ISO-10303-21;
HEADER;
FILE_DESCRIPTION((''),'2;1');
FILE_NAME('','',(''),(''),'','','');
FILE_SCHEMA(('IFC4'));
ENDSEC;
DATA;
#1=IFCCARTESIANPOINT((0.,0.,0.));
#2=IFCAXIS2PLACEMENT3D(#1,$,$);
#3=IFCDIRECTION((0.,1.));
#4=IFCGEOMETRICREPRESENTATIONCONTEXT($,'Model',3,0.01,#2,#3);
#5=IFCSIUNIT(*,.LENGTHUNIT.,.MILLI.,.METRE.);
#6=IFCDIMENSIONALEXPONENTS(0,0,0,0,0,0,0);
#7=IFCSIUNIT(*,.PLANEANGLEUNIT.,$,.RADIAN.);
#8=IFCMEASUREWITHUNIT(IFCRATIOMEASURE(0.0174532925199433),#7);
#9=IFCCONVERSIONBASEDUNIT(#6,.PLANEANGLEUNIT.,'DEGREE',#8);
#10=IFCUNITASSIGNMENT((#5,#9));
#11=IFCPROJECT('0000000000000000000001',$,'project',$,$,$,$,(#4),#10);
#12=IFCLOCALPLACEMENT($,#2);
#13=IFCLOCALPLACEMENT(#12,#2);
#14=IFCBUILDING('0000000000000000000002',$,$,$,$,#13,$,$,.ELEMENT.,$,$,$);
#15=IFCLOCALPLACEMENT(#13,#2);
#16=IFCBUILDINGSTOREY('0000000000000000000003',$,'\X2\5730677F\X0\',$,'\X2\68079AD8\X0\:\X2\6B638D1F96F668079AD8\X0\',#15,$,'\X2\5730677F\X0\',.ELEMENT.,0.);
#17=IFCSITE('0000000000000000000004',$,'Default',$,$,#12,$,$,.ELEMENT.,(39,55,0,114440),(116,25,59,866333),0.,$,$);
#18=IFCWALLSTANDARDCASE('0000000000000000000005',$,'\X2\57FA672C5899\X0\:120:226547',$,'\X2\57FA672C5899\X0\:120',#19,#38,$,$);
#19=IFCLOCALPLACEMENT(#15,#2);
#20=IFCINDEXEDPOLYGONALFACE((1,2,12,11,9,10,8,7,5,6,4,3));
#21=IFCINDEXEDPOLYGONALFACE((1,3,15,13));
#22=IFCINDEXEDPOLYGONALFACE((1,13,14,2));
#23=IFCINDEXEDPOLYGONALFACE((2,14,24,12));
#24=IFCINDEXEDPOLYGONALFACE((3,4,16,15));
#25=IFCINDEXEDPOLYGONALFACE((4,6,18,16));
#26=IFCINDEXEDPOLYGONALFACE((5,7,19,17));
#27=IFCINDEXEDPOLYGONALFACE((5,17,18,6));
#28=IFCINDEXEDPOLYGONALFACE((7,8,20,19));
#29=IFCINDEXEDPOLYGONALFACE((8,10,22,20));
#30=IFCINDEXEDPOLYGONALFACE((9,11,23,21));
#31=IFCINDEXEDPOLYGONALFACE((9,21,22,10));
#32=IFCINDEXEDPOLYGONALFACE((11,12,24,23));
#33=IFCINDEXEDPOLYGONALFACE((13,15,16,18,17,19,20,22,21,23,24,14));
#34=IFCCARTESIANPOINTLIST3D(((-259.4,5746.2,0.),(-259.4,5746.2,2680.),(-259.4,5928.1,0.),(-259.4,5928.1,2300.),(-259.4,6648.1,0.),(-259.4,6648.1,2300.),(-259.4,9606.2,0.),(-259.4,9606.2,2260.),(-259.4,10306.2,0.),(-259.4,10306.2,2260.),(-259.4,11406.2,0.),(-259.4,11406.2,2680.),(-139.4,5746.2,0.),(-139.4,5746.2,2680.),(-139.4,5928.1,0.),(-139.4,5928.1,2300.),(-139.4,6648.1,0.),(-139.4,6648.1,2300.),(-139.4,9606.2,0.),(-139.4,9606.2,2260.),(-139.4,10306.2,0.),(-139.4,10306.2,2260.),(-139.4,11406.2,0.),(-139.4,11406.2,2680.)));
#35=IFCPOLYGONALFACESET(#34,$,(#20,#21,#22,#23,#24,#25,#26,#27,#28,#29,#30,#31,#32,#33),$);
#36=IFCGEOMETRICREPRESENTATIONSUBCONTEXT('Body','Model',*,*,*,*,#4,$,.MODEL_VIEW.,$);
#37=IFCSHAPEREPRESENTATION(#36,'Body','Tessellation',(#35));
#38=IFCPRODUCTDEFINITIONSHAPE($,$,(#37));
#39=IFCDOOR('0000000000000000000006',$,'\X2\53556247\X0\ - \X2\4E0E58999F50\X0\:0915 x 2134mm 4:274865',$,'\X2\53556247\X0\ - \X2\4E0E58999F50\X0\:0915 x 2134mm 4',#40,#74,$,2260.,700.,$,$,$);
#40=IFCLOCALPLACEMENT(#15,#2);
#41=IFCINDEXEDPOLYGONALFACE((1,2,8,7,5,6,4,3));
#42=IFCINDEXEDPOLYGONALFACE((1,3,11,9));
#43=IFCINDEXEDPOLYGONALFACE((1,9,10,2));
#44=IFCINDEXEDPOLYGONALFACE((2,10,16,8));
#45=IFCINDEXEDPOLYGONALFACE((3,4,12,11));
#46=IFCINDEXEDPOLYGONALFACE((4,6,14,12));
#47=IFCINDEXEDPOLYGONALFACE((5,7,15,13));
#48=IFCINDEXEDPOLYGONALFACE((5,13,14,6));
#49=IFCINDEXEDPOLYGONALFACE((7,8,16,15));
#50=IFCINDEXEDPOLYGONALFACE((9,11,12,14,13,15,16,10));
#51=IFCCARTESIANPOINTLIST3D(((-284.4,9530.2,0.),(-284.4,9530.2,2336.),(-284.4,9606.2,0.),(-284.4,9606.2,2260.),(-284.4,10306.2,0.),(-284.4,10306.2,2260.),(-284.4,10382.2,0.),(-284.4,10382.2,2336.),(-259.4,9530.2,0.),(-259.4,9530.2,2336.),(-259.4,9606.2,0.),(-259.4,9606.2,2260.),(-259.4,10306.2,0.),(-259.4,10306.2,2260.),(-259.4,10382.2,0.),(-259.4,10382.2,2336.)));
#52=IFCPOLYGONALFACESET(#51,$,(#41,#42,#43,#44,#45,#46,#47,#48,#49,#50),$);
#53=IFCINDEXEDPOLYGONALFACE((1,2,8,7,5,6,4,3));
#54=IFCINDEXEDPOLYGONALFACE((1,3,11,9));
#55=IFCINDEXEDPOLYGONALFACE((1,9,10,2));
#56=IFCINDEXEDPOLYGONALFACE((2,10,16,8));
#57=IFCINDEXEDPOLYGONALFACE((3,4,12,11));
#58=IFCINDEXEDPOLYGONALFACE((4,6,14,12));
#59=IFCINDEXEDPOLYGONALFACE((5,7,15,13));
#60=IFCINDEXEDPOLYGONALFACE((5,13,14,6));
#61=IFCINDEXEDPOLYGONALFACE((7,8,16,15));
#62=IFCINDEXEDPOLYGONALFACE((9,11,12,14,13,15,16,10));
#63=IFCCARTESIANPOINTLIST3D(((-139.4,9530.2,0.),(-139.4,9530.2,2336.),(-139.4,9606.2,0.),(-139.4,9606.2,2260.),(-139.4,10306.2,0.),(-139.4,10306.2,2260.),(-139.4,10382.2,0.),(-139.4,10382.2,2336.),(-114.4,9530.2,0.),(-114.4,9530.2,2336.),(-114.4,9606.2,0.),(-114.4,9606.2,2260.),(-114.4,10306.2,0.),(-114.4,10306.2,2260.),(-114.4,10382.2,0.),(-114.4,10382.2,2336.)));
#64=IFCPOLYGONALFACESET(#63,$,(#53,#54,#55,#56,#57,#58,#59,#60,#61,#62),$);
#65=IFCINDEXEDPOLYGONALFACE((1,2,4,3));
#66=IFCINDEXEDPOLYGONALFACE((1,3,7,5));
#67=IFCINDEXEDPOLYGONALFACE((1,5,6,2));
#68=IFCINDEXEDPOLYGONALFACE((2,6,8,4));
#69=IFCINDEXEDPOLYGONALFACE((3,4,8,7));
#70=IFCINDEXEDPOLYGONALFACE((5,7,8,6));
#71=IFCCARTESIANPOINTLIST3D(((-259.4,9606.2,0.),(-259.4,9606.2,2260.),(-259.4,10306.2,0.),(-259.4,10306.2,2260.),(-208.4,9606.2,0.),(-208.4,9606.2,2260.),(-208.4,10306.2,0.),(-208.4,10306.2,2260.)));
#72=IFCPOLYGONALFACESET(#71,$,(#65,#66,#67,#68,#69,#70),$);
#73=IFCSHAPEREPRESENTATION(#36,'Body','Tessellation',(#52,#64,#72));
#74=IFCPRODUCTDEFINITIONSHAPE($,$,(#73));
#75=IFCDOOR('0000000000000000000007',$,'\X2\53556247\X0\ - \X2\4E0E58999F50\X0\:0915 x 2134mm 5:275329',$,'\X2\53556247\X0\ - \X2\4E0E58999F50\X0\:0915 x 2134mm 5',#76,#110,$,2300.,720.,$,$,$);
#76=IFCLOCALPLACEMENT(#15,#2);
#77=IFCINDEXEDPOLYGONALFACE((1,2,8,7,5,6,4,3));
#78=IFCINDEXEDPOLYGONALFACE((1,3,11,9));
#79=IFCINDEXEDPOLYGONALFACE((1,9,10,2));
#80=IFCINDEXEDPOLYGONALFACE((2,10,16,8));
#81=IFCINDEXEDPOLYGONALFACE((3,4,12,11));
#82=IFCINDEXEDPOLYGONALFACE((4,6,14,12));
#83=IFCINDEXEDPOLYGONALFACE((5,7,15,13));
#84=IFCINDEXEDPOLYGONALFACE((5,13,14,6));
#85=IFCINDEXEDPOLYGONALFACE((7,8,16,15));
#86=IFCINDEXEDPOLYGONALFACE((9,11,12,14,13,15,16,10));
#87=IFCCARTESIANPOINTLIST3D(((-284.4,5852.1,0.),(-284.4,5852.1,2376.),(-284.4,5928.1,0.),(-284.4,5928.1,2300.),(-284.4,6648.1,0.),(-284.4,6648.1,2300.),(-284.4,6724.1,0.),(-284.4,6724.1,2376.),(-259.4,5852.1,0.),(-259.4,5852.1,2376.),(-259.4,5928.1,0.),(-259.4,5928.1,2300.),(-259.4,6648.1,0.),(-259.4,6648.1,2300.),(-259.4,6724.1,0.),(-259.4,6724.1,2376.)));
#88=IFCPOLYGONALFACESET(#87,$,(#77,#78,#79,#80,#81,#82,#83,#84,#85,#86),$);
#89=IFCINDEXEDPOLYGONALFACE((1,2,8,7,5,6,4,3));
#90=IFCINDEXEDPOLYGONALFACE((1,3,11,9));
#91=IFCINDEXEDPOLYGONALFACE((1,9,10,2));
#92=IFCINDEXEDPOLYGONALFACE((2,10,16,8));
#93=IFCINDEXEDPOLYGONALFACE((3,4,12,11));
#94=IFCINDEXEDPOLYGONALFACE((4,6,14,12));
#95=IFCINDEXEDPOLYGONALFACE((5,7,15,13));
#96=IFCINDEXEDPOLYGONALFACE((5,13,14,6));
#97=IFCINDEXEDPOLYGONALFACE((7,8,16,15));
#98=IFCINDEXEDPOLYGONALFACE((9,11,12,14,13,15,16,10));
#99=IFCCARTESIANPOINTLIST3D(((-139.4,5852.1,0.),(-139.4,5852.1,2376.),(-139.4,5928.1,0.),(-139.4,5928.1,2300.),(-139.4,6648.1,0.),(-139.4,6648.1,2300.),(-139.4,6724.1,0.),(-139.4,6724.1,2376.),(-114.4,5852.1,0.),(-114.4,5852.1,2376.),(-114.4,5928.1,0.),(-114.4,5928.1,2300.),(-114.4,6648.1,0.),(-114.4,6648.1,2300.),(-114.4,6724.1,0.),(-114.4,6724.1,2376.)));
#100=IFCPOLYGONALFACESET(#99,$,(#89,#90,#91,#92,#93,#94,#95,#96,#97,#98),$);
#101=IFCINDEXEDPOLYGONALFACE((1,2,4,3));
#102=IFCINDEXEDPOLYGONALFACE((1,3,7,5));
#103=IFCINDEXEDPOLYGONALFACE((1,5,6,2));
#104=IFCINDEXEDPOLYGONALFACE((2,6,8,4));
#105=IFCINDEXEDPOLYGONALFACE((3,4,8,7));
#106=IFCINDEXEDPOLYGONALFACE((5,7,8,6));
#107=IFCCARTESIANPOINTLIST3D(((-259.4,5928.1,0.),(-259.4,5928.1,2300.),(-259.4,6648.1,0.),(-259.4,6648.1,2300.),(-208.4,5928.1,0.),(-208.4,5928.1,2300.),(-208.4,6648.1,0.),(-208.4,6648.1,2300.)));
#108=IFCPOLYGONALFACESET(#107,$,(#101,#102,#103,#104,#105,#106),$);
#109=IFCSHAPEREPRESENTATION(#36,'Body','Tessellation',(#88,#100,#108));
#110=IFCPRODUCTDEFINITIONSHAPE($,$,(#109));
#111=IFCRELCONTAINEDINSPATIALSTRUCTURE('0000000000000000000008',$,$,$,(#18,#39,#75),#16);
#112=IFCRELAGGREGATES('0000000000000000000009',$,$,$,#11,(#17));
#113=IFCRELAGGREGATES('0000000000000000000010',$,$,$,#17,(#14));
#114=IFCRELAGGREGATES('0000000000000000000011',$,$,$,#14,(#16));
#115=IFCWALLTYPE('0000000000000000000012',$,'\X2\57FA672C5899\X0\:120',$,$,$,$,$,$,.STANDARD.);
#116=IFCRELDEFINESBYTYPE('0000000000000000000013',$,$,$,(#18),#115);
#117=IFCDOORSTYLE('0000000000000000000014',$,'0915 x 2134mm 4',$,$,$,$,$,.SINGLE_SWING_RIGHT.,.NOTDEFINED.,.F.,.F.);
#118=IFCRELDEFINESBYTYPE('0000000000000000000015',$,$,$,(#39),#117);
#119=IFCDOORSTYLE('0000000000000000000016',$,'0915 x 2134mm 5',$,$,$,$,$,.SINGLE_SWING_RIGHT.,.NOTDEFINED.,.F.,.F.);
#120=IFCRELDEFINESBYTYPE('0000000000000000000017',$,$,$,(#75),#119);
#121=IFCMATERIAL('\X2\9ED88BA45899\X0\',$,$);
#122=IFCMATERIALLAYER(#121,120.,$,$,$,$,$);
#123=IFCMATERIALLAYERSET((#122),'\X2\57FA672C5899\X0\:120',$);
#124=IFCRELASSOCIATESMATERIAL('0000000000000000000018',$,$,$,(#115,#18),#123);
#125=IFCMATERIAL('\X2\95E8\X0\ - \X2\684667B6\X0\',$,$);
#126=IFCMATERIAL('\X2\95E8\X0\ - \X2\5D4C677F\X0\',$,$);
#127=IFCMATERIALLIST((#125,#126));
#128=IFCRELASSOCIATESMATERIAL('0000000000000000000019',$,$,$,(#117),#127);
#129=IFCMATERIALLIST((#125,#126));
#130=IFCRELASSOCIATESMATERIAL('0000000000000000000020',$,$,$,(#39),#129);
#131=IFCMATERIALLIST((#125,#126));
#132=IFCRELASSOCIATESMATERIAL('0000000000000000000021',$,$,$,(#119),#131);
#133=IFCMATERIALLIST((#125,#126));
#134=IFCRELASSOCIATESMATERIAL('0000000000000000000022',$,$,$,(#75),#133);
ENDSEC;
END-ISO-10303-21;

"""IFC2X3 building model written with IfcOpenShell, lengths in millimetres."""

from ifc_helpers import new_model, entity, si_unit, converted_unit, direction, frame, frame_2d, origin, origin_2d_with_axis, place, context, subcontext, project, spatial, polyline, rectangle, outline, extrude, source, transform, mapped, material, material_list, layer, layer_set, layer_usage, type_object, type_shapes, element, fill, save


model = new_model("IFC2X3")

# Units and contexts
model_context = context("Model", 3, precision=0.01, world=origin(), true_north=direction((0.0, 1.0)))
body_context = subcontext(model_context, "Body", "Model", "MODEL_VIEW")
ifc_project = project(units=[si_unit("LENGTHUNIT", "METRE", prefix="MILLI"), converted_unit("PLANEANGLEUNIT", "DEGREE", entity("IfcRatioMeasure", 0.0174532925199433), si_unit("PLANEANGLEUNIT", "RADIAN"), dimensions=[0, 0, 0, 0, 0, 0, 0])], contexts=[model_context])

# Site, building, storey
site_placement = place(None, origin())
site = spatial("IfcSite", under=ifc_project, at=site_placement, Name="Default", CompositionType="ELEMENT", RefLatitude=(39, 55, 0, 114440), RefLongitude=(116, 25, 59, 866333), RefElevation=0.0)
building_placement = place(site_placement, origin())
building = spatial("IfcBuilding", under=site, at=building_placement, CompositionType="ELEMENT")
storey_placement = place(building_placement, origin())
storey = spatial("IfcBuildingStorey", under=building, at=storey_placement, Name="地板", ObjectType="标高:正负零标高", LongName="地板", CompositionType="ELEMENT", Elevation=0.0)

# Shared definitions
ifc_material_1 = material(Name="默认墙")

# Shared definitions
ifc_material_2 = material(Name="门 - 框架")
ifc_material_3 = material(Name="门 - 嵌板")

# Wall, openings, doors
ifc_layer_1 = layer(ifc_material_1, 120.0)
ifc_layer_set_1 = layer_set([ifc_layer_1], Name="基本墙:120")
ifc_layer_usage_1 = layer_usage(ifc_layer_set_1, "AXIS2", "NEGATIVE", 60.0)
wall_type_1 = type_object("IfcWallType", Name="基本墙:120", PredefinedType="STANDARD", material=ifc_layer_set_1)
wall_1_placement = place(storey_placement, frame((-199.4, 5746.2, 0.0), z_axis=(0.0, 0.0, 1.0), x_axis=(0.0, 1.0, 0.0)))
wall_1 = element("IfcWallStandardCase", 1, at=wall_1_placement, inside=storey, type_object=wall_type_1, material=ifc_layer_usage_1, Name="基本墙:120:226547", ObjectType="基本墙:120", context=body_context, shape_type="SweptSolid", body=[
    extrude(rectangle(XDim=5660.0, YDim=120.0, at=frame_2d((2830.0, 0.0), x_axis=(-1.0, 0.0))), origin(), (0.0, 0.0, 1.0), 2680.0),
])
opening_1_placement = place(wall_1_placement, frame((3860.0, -60.0, 0.0)))
opening_1 = element("IfcOpeningElement", 2, at=opening_1_placement, cuts=wall_1, ObjectType="Opening", context=body_context, shape_type="SweptSolid", body=[
    extrude(rectangle(XDim=700.0, YDim=2260.0, at=frame_2d((1130.0, 350.0), x_axis=(0.0, 1.0))), frame((0.0, 0.0, 0.0), z_axis=(0.0, 1.0, 0.0), x_axis=(0.0, 0.0, 1.0)), (0.0, 0.0, 1.0), 120.0),
])
opening_2_placement = place(wall_1_placement, frame((182.0, -60.0, 0.0)))
opening_2 = element("IfcOpeningElement", 3, at=opening_2_placement, cuts=wall_1, ObjectType="Opening", context=body_context, shape_type="SweptSolid", body=[
    extrude(rectangle(XDim=720.0, YDim=2300.0, at=frame_2d((1150.0, 360.0), x_axis=(0.0, 1.0))), frame((0.0, 0.0, 0.0), z_axis=(0.0, 1.0, 0.0), x_axis=(0.0, 0.0, 1.0)), (0.0, 0.0, 1.0), 120.0),
])
ifc_material_list_1 = material_list([ifc_material_2, ifc_material_3])
ifc_material_list_2 = material_list([ifc_material_2, ifc_material_3])
door_style_1 = type_object("IfcDoorStyle", Name="0915 x 2134mm 4", ConstructionType="NOTDEFINED", OperationType="SINGLE_SWING_RIGHT", ParameterTakesPrecedence=False, Sizeable=False, material=ifc_material_list_2)
shared_shape_1 = source(origin(), body_context, "Body", "SweptSolid", [
    extrude(outline(polyline([(-426.0, -1187.0), (426.0, -1187.0), (426.0, 1149.0), (350.0, 1149.0), (350.0, -1111.0), (-350.0, -1111.0), (-350.0, 1149.0), (-426.0, 1149.0), (-426.0, -1187.0)])), frame((350.0, 120.0, 1149.0), z_axis=(0.0, 1.0, 0.0), x_axis=(1.0, 0.0, 0.0)), (0.0, 0.0, 1.0), 25.0),
    extrude(outline(polyline([(-1187.0, -426.0), (1149.0, -426.0), (1149.0, -350.0), (-1111.0, -350.0), (-1111.0, 350.0), (1149.0, 350.0), (1149.0, 426.0), (-1187.0, 426.0), (-1187.0, -426.0)])), frame((350.0, -25.0, 1149.0), z_axis=(0.0, 1.0, 0.0), x_axis=(0.0, 0.0, -1.0)), (0.0, 0.0, 1.0), 25.0),
    extrude(rectangle(XDim=51.0, YDim=700.0, at=origin_2d_with_axis()), frame((350.0, 94.5, 0.0), z_axis=(0.0, 0.0, 1.0), x_axis=(0.0, 1.0, 0.0)), (0.0, 0.0, 1.0), 2260.0),
])
type_shapes(door_style_1, [shared_shape_1])
door_1_placement = place(opening_1_placement, origin())
door_1 = element("IfcDoor", 4, at=door_1_placement, inside=storey, type_object=door_style_1, material=ifc_material_list_1, Name="单扇 - 与墙齐:0915 x 2134mm 4:274865", ObjectType="单扇 - 与墙齐:0915 x 2134mm 4", OverallHeight=2260.0, OverallWidth=700.0, context=body_context, shape_type="MappedRepresentation", body=[
    mapped(shared_shape_1, transform((0.0, 0.0, 0.0), scale=1.0)),
])
fill(opening_1, door_1)
ifc_material_list_3 = material_list([ifc_material_2, ifc_material_3])
ifc_material_list_4 = material_list([ifc_material_2, ifc_material_3])
door_style_2 = type_object("IfcDoorStyle", Name="0915 x 2134mm 5", ConstructionType="NOTDEFINED", OperationType="SINGLE_SWING_RIGHT", ParameterTakesPrecedence=False, Sizeable=False, material=ifc_material_list_4)
shared_shape_2 = source(origin(), body_context, "Body", "SweptSolid", [
    extrude(outline(polyline([(-436.0, -1207.0), (436.0, -1207.0), (436.0, 1169.0), (360.0, 1169.0), (360.0, -1131.0), (-360.0, -1131.0), (-360.0, 1169.0), (-436.0, 1169.0), (-436.0, -1207.0)])), frame((360.0, 120.0, 1169.0), z_axis=(0.0, 1.0, 0.0), x_axis=(1.0, 0.0, 0.0)), (0.0, 0.0, 1.0), 25.0),
    extrude(outline(polyline([(-1207.0, -436.0), (1169.0, -436.0), (1169.0, -360.0), (-1131.0, -360.0), (-1131.0, 360.0), (1169.0, 360.0), (1169.0, 436.0), (-1207.0, 436.0), (-1207.0, -436.0)])), frame((360.0, -25.0, 1169.0), z_axis=(0.0, 1.0, 0.0), x_axis=(0.0, 0.0, -1.0)), (0.0, 0.0, 1.0), 25.0),
    extrude(rectangle(XDim=51.0, YDim=720.0, at=origin_2d_with_axis()), frame((360.0, 94.5, 0.0), z_axis=(0.0, 0.0, 1.0), x_axis=(0.0, 1.0, 0.0)), (0.0, 0.0, 1.0), 2300.0),
])
type_shapes(door_style_2, [shared_shape_2])
door_2_placement = place(opening_2_placement, origin())
door_2 = element("IfcDoor", 5, at=door_2_placement, inside=storey, type_object=door_style_2, material=ifc_material_list_3, Name="单扇 - 与墙齐:0915 x 2134mm 5:275329", ObjectType="单扇 - 与墙齐:0915 x 2134mm 5", OverallHeight=2300.0, OverallWidth=720.0, context=body_context, shape_type="MappedRepresentation", body=[
    mapped(shared_shape_2, transform((0.0, 0.0, 0.0), scale=1.0)),
])
fill(opening_2, door_2)

save(model, "model.ifc")
